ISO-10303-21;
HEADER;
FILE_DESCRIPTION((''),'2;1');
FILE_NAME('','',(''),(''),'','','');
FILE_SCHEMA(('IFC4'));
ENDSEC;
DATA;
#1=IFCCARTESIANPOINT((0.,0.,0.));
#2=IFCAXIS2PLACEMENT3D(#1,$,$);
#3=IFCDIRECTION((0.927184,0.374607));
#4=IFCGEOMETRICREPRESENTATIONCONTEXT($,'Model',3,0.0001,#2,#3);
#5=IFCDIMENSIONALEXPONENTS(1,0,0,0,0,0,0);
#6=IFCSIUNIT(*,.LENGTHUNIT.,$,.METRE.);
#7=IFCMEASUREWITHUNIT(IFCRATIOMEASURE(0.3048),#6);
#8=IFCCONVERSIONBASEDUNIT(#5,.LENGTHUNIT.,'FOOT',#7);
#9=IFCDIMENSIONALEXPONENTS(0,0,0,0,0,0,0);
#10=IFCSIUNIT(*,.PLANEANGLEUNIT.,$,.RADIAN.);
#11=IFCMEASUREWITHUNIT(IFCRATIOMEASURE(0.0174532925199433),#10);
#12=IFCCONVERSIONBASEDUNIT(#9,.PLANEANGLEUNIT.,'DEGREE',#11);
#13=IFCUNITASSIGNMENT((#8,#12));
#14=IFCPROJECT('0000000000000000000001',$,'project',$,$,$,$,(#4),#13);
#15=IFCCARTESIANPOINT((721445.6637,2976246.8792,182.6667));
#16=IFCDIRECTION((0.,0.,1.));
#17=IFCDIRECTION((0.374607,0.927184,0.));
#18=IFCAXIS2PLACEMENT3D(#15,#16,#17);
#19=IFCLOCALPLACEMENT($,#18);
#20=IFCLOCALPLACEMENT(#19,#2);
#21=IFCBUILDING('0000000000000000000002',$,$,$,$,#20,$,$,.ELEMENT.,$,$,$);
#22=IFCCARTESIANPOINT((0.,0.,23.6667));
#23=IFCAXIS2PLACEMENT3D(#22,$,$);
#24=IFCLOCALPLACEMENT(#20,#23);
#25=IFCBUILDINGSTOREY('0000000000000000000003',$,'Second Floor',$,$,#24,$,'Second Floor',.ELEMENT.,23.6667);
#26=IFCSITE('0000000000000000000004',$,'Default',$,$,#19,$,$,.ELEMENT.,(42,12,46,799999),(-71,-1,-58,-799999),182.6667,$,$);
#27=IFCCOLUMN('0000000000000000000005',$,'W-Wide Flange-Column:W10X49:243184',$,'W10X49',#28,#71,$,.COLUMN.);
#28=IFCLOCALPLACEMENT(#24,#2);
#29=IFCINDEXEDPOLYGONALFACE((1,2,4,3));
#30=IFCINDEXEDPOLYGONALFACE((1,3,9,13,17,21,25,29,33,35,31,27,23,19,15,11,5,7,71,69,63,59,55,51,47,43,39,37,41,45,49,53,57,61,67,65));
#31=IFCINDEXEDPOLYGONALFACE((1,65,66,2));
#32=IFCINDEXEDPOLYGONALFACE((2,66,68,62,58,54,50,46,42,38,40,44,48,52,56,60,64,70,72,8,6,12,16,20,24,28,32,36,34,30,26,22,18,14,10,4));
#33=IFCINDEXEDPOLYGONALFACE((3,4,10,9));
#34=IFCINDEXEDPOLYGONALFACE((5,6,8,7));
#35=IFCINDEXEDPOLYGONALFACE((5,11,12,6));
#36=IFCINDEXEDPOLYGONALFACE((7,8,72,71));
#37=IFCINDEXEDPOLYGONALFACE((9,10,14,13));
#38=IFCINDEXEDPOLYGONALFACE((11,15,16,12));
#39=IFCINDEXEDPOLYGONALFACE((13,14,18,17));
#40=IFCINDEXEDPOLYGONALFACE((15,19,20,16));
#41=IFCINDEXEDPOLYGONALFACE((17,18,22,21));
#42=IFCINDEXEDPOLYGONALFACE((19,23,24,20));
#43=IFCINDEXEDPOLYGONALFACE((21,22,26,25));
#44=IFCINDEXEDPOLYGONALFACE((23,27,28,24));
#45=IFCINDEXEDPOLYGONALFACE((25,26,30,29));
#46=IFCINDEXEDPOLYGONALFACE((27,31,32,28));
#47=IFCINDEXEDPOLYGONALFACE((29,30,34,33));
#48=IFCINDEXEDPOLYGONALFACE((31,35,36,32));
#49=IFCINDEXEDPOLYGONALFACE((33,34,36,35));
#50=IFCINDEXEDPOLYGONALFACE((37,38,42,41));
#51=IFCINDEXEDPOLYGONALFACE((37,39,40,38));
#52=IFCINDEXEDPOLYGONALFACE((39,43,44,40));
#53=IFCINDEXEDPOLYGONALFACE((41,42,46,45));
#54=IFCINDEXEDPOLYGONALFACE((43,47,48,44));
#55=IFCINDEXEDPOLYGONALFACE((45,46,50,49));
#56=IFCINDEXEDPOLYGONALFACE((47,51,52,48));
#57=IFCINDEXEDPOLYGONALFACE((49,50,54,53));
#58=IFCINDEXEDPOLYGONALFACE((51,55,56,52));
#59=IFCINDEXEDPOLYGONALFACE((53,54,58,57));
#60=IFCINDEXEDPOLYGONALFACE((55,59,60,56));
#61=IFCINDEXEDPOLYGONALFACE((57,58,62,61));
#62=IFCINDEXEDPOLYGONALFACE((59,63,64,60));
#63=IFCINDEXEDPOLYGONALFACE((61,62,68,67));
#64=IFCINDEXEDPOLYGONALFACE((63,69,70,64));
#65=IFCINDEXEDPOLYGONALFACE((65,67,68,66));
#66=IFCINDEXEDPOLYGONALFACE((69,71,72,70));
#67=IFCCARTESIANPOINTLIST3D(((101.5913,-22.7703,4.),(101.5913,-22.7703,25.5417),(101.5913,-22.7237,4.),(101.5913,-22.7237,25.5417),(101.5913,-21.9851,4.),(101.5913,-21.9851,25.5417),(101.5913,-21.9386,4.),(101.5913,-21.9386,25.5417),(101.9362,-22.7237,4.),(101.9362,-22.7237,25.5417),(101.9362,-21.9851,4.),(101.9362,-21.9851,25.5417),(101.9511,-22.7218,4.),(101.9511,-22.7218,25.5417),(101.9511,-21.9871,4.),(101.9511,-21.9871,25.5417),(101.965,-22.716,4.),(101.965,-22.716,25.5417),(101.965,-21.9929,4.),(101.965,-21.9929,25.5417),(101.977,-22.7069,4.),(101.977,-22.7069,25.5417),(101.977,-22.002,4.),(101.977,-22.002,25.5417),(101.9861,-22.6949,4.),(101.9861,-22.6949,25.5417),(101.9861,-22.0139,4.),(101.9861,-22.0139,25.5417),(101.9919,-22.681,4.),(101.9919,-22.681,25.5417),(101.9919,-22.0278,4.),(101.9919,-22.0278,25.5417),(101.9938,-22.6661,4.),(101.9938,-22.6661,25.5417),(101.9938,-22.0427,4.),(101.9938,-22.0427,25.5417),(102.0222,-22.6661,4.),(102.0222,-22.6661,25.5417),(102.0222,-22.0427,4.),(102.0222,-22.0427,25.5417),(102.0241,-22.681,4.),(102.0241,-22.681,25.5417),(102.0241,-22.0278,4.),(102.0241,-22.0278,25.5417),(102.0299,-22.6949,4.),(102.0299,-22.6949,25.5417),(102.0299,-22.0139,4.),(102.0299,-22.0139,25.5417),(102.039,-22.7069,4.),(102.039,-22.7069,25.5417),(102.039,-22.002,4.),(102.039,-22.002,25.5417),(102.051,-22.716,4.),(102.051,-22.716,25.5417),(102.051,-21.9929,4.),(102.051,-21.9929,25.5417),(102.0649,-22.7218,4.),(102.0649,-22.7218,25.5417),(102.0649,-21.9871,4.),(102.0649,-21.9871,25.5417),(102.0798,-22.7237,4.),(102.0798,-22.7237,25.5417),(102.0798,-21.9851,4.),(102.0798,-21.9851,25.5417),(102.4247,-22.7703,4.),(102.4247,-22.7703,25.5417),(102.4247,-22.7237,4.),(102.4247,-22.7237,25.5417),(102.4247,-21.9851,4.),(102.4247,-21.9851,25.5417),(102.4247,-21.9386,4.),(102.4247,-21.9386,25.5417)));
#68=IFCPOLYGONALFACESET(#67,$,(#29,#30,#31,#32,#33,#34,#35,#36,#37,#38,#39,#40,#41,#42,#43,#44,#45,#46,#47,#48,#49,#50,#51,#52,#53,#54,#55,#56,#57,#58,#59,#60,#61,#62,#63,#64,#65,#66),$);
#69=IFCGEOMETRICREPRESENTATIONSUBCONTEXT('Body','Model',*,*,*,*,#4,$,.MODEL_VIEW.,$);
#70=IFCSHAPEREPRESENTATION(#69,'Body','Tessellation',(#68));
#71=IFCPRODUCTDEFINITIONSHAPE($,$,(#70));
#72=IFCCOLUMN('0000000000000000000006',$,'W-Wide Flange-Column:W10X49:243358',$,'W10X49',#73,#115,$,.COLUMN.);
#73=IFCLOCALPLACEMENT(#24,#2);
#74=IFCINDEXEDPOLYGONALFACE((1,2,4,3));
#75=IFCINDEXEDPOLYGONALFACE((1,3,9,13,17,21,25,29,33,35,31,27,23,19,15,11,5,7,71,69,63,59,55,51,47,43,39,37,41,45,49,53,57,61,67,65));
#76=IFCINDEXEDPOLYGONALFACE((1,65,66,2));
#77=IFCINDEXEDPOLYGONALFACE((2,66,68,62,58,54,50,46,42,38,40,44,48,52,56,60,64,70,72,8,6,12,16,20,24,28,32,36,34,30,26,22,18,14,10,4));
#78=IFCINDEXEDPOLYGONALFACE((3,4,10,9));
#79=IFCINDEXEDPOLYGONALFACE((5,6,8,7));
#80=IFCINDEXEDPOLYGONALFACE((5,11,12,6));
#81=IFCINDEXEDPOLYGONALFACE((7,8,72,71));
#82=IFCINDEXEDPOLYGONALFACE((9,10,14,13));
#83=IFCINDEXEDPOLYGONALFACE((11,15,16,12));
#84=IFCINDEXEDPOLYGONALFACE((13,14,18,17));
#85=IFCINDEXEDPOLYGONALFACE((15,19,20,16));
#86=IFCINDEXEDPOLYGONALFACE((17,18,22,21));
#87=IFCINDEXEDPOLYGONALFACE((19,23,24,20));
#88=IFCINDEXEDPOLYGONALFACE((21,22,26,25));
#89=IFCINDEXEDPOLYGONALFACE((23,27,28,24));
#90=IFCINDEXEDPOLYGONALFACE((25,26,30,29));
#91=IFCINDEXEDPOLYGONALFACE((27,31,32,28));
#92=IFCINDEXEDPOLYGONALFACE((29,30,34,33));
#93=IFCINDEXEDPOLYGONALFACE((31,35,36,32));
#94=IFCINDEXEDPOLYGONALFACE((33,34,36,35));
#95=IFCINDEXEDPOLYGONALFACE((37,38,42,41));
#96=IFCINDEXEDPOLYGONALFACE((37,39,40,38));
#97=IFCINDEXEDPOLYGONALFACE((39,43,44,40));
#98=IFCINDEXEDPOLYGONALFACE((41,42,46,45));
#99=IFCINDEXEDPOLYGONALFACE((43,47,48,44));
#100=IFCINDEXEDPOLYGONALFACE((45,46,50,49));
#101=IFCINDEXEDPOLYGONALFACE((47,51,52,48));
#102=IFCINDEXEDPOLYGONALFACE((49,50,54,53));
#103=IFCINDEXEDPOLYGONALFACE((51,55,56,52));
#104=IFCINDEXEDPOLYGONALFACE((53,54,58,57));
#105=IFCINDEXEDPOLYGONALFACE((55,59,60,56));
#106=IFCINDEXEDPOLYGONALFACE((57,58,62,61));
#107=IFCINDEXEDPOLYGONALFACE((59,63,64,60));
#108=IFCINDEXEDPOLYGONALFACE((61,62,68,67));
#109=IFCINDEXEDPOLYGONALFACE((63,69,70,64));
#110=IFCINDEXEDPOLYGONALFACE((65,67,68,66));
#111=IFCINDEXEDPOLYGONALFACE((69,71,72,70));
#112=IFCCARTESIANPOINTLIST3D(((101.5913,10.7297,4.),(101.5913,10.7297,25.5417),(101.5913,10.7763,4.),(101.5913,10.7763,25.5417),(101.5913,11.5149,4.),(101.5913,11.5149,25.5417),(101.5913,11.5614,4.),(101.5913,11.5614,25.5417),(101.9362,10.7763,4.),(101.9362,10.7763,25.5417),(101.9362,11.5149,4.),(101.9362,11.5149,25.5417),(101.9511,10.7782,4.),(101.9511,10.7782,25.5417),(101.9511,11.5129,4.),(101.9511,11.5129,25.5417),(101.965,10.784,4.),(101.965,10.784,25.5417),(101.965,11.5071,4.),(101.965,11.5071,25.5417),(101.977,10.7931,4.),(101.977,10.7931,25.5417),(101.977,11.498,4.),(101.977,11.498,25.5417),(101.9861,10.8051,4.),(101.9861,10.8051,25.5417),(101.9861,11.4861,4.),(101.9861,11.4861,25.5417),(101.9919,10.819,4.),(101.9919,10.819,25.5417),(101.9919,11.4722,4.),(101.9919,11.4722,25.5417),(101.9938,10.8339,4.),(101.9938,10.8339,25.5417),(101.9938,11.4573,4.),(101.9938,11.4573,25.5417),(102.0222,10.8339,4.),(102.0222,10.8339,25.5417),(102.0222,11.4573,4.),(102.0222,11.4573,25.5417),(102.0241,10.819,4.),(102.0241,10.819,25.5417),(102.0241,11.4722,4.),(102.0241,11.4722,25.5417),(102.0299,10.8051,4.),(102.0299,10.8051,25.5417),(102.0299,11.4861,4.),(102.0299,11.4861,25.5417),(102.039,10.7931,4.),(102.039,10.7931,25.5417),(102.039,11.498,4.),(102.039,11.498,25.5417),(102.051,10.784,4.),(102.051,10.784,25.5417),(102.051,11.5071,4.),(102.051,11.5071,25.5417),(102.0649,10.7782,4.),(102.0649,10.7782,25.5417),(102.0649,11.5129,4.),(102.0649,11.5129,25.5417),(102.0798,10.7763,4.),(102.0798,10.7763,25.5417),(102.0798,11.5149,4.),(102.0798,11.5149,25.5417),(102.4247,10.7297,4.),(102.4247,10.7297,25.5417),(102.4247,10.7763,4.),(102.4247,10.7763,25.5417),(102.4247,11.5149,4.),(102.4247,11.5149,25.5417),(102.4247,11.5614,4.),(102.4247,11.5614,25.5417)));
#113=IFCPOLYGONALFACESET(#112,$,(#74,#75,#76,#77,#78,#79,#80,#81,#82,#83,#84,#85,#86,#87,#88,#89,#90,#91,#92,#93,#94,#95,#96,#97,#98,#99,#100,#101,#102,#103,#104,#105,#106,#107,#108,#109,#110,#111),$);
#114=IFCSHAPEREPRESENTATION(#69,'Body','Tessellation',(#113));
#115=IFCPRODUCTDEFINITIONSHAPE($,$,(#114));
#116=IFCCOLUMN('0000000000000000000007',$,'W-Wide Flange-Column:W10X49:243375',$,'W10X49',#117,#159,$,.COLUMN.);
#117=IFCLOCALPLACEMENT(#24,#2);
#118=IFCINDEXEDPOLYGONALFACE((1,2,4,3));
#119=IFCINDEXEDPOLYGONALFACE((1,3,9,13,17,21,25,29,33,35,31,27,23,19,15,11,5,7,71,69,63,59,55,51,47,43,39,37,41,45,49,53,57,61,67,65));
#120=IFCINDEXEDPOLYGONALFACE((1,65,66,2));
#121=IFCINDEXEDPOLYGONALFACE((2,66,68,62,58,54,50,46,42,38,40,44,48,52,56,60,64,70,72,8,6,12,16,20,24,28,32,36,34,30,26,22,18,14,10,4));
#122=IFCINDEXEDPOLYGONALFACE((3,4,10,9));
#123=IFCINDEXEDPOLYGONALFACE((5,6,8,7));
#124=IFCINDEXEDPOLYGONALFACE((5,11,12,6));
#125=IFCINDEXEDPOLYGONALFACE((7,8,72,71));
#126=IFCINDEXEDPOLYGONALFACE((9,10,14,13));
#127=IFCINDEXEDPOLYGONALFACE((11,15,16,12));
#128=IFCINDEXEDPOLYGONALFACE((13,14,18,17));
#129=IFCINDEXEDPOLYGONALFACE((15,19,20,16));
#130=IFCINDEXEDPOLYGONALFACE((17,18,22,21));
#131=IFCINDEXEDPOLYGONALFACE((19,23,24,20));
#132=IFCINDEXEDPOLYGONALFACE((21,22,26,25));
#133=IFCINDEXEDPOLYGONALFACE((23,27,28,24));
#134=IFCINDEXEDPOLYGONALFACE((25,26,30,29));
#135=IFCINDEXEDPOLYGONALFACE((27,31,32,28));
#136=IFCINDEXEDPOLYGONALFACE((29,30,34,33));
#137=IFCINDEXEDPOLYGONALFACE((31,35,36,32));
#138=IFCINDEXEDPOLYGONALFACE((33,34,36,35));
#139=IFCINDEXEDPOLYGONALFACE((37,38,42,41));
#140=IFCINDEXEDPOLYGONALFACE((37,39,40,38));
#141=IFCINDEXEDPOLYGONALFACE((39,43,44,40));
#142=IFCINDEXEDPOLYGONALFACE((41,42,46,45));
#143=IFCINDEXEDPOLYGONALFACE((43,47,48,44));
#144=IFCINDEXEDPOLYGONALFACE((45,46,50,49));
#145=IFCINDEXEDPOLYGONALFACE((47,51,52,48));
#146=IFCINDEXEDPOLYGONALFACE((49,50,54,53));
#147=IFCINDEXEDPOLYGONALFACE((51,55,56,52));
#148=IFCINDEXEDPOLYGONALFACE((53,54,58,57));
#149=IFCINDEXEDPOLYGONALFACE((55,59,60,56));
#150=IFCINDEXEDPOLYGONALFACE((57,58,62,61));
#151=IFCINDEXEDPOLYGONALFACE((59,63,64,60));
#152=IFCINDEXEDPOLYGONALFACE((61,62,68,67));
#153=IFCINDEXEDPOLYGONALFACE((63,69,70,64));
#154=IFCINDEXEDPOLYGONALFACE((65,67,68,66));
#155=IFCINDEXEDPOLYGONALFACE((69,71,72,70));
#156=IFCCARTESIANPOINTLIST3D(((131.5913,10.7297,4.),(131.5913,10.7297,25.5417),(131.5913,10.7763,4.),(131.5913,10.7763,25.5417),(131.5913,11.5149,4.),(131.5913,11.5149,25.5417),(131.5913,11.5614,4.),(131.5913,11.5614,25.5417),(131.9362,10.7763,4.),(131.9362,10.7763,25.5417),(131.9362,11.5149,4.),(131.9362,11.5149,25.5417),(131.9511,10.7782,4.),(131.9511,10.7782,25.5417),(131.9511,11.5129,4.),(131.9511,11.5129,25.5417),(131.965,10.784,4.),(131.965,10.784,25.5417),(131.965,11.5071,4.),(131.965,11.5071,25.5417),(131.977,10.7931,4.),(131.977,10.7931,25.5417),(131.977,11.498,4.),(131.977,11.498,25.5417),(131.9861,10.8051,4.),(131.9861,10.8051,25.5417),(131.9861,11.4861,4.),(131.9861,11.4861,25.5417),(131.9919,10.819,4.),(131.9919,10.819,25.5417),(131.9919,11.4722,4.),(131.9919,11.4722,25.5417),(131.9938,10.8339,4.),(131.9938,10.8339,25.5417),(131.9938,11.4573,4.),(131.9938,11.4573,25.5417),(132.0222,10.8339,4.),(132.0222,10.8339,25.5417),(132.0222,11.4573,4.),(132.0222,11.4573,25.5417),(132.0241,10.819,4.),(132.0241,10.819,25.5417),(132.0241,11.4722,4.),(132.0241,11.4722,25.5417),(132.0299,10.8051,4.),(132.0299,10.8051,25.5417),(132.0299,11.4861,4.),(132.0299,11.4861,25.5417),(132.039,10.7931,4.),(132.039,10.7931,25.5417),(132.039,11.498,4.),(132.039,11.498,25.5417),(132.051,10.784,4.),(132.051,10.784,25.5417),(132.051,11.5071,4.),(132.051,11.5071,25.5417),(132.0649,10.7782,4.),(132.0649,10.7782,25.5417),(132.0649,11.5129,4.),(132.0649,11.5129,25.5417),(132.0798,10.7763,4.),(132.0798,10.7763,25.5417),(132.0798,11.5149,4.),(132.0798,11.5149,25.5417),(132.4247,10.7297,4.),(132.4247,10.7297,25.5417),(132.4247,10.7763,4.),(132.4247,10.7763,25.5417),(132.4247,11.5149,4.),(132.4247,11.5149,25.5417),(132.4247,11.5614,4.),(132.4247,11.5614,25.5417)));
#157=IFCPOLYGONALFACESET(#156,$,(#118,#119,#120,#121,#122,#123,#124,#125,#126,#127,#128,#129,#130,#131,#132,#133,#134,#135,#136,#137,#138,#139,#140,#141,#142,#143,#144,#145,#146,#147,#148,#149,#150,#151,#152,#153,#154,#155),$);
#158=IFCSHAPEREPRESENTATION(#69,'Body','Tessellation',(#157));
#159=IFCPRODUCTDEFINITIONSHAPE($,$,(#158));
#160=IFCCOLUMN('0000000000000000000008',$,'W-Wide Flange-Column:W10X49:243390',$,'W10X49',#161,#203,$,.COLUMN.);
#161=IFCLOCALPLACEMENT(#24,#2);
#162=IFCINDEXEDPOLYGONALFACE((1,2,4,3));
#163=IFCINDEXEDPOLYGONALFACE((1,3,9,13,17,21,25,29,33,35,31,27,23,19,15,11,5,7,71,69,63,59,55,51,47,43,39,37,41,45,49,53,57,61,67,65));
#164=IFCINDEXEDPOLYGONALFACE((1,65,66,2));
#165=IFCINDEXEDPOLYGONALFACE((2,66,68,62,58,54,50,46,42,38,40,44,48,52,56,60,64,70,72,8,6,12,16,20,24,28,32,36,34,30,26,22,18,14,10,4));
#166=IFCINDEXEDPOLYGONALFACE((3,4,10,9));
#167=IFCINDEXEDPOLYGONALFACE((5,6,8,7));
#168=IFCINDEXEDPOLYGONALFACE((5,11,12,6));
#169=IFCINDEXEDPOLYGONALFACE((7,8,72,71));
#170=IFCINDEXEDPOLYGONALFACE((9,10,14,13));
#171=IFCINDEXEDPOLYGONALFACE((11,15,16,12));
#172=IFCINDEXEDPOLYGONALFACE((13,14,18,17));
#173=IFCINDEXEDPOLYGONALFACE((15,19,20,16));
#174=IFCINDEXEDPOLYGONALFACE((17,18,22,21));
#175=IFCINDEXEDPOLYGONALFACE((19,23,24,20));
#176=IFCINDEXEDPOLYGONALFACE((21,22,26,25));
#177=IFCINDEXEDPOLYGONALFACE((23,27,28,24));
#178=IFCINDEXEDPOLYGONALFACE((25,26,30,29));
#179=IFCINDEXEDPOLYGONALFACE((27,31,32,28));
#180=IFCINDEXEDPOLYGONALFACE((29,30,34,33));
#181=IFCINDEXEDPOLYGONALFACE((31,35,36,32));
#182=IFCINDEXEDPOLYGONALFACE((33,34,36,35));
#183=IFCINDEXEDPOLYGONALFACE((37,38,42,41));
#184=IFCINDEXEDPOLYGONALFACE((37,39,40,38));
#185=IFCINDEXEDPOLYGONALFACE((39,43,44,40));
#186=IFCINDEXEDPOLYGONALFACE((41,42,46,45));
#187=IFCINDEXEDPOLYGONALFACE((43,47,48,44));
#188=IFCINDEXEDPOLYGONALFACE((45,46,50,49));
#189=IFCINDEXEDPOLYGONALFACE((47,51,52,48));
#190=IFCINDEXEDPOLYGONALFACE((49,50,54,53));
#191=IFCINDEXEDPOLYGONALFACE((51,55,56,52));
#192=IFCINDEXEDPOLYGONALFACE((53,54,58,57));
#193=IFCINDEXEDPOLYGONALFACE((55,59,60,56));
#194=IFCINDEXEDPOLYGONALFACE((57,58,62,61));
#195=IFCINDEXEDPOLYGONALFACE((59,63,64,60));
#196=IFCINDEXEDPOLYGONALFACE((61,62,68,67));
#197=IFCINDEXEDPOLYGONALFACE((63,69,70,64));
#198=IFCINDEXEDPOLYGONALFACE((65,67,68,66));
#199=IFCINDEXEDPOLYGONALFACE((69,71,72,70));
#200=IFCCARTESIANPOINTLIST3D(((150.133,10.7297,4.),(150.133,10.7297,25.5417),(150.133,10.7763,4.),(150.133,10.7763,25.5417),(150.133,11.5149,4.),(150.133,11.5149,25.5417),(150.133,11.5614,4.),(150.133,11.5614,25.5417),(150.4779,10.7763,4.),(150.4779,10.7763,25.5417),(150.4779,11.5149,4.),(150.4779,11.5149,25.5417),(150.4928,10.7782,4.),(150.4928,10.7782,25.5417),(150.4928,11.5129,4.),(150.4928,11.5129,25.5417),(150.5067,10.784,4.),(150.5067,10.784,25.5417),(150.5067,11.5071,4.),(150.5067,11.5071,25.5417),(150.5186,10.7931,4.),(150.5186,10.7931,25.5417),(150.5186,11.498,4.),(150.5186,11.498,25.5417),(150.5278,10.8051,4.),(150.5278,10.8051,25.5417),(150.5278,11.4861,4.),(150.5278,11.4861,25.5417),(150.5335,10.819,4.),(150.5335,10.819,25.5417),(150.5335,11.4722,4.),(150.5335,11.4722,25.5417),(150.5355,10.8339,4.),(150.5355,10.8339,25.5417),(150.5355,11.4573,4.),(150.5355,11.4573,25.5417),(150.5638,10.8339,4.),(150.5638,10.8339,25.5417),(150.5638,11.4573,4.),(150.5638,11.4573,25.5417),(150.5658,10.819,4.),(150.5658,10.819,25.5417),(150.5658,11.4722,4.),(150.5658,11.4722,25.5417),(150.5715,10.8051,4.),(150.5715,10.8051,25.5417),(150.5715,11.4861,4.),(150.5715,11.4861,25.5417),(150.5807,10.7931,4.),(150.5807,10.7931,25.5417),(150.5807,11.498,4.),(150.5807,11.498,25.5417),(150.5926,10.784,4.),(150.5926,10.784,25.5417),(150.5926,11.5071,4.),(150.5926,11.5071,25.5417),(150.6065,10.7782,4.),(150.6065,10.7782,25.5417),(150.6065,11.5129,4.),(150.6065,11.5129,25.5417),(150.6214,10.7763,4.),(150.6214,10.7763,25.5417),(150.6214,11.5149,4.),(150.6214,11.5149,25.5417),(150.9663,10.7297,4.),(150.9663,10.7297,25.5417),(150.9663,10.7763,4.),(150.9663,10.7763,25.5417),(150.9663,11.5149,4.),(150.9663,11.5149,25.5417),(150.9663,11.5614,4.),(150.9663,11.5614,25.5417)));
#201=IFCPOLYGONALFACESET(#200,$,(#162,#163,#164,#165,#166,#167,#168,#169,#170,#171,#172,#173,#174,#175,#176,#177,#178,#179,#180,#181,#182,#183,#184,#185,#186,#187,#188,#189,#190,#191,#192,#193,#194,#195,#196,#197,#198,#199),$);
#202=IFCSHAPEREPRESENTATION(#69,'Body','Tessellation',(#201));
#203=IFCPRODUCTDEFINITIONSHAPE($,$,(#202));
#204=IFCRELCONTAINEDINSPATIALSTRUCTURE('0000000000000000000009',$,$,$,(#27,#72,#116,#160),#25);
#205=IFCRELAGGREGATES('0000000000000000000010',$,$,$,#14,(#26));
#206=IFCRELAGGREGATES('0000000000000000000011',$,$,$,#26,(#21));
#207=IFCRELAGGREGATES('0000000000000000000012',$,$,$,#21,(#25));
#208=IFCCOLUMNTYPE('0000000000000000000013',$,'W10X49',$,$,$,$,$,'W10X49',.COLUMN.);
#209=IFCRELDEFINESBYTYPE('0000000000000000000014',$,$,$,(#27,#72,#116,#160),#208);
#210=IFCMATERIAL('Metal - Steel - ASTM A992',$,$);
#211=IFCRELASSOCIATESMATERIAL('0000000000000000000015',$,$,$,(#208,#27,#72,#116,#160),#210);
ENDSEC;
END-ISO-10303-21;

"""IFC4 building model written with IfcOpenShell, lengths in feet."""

from ifc_helpers import new_model, entity, si_unit, converted_unit, direction, frame, frame_2d, origin, place, context, subcontext, project, spatial, i_section, extrude, source, transform, mapped, material, type_object, type_shapes, element, save


model = new_model("IFC4")

# Units and contexts
model_context = context("Model", 3, precision=0.0001, world=origin(), true_north=direction((0.927184, 0.374607)))
body_context = subcontext(model_context, "Body", "Model", "MODEL_VIEW")
ifc_project = project(units=[converted_unit("LENGTHUNIT", "FOOT", entity("IfcRatioMeasure", 0.3048), si_unit("LENGTHUNIT", "METRE"), dimensions=[1, 0, 0, 0, 0, 0, 0]), converted_unit("PLANEANGLEUNIT", "DEGREE", entity("IfcRatioMeasure", 0.0174532925199433), si_unit("PLANEANGLEUNIT", "RADIAN"), dimensions=[0, 0, 0, 0, 0, 0, 0])], contexts=[model_context])

# Site, building, storey
site_placement = place(None, frame((721445.6637, 2976246.8792, 182.6667), z_axis=(0.0, 0.0, 1.0), x_axis=(0.374607, 0.927184, 0.0)))
site = spatial("IfcSite", under=ifc_project, at=site_placement, Name="Default", CompositionType="ELEMENT", RefLatitude=(42, 12, 46, 799999), RefLongitude=(-71, -1, -58, -799999), RefElevation=182.6667)
building_placement = place(site_placement, origin())
building = spatial("IfcBuilding", under=site, at=building_placement, CompositionType="ELEMENT")
storey_placement = place(building_placement, frame((0.0, 0.0, 23.6667)))
storey = spatial("IfcBuildingStorey", under=building, at=storey_placement, Name="Second Floor", LongName="Second Floor", CompositionType="ELEMENT", Elevation=23.6667)

# Columns
ifc_material_1 = material(Name="Metal - Steel - ASTM A992")
column_type = type_object("IfcColumnType", Name="W10X49", ElementType="W10X49", PredefinedType="COLUMN", material=ifc_material_1)
shared_shape_1 = source(origin(), body_context, "Body", "SweptSolid", [
    extrude(i_section(OverallWidth=0.8333, OverallDepth=0.8317, WebThickness=0.0283, FlangeThickness=0.0465, FilletRadius=0.0576, at=frame_2d((0.0, 0.0), x_axis=(0.0, 1.0))), frame((0.0, 0.0, 27.6667), z_axis=(0.0, 0.0, 1.0), x_axis=(0.0, -1.0, 0.0)), (0.0, 0.0, 1.0), 21.5417),
])
type_shapes(column_type, [shared_shape_1])
for number, where, z_axis, x_axis, name in (
    (1, (102.008, -22.3544, -23.6667), (0.0, 0.0, 1.0), (-1.0, 0.0, 0.0), "W-Wide Flange-Column:W10X49:243184"),
    (2, (102.008, 11.1456, -23.6667), (0.0, 0.0, 1.0), (-1.0, 0.0, 0.0), "W-Wide Flange-Column:W10X49:243358"),
    (3, (132.008, 11.1456, -23.6667), (0.0, 0.0, 1.0), (-1.0, 0.0, 0.0), "W-Wide Flange-Column:W10X49:243375"),
    (4, (150.5497, 11.1456, -23.6667), (0.0, 0.0, 1.0), (-1.0, 0.0, 0.0), "W-Wide Flange-Column:W10X49:243390"),
):
    element("IfcColumn", number, at=place(storey_placement, frame(where, z_axis=z_axis, x_axis=x_axis)), inside=storey, type_object=column_type, material=ifc_material_1, Name=name, ObjectType="W10X49", PredefinedType="COLUMN", context=body_context, shape_type="MappedRepresentation", body=[
        mapped(shared_shape_1, transform((0.0, 0.0, 0.0), scale=1.0)),
    ])

save(model, "model.ifc")
